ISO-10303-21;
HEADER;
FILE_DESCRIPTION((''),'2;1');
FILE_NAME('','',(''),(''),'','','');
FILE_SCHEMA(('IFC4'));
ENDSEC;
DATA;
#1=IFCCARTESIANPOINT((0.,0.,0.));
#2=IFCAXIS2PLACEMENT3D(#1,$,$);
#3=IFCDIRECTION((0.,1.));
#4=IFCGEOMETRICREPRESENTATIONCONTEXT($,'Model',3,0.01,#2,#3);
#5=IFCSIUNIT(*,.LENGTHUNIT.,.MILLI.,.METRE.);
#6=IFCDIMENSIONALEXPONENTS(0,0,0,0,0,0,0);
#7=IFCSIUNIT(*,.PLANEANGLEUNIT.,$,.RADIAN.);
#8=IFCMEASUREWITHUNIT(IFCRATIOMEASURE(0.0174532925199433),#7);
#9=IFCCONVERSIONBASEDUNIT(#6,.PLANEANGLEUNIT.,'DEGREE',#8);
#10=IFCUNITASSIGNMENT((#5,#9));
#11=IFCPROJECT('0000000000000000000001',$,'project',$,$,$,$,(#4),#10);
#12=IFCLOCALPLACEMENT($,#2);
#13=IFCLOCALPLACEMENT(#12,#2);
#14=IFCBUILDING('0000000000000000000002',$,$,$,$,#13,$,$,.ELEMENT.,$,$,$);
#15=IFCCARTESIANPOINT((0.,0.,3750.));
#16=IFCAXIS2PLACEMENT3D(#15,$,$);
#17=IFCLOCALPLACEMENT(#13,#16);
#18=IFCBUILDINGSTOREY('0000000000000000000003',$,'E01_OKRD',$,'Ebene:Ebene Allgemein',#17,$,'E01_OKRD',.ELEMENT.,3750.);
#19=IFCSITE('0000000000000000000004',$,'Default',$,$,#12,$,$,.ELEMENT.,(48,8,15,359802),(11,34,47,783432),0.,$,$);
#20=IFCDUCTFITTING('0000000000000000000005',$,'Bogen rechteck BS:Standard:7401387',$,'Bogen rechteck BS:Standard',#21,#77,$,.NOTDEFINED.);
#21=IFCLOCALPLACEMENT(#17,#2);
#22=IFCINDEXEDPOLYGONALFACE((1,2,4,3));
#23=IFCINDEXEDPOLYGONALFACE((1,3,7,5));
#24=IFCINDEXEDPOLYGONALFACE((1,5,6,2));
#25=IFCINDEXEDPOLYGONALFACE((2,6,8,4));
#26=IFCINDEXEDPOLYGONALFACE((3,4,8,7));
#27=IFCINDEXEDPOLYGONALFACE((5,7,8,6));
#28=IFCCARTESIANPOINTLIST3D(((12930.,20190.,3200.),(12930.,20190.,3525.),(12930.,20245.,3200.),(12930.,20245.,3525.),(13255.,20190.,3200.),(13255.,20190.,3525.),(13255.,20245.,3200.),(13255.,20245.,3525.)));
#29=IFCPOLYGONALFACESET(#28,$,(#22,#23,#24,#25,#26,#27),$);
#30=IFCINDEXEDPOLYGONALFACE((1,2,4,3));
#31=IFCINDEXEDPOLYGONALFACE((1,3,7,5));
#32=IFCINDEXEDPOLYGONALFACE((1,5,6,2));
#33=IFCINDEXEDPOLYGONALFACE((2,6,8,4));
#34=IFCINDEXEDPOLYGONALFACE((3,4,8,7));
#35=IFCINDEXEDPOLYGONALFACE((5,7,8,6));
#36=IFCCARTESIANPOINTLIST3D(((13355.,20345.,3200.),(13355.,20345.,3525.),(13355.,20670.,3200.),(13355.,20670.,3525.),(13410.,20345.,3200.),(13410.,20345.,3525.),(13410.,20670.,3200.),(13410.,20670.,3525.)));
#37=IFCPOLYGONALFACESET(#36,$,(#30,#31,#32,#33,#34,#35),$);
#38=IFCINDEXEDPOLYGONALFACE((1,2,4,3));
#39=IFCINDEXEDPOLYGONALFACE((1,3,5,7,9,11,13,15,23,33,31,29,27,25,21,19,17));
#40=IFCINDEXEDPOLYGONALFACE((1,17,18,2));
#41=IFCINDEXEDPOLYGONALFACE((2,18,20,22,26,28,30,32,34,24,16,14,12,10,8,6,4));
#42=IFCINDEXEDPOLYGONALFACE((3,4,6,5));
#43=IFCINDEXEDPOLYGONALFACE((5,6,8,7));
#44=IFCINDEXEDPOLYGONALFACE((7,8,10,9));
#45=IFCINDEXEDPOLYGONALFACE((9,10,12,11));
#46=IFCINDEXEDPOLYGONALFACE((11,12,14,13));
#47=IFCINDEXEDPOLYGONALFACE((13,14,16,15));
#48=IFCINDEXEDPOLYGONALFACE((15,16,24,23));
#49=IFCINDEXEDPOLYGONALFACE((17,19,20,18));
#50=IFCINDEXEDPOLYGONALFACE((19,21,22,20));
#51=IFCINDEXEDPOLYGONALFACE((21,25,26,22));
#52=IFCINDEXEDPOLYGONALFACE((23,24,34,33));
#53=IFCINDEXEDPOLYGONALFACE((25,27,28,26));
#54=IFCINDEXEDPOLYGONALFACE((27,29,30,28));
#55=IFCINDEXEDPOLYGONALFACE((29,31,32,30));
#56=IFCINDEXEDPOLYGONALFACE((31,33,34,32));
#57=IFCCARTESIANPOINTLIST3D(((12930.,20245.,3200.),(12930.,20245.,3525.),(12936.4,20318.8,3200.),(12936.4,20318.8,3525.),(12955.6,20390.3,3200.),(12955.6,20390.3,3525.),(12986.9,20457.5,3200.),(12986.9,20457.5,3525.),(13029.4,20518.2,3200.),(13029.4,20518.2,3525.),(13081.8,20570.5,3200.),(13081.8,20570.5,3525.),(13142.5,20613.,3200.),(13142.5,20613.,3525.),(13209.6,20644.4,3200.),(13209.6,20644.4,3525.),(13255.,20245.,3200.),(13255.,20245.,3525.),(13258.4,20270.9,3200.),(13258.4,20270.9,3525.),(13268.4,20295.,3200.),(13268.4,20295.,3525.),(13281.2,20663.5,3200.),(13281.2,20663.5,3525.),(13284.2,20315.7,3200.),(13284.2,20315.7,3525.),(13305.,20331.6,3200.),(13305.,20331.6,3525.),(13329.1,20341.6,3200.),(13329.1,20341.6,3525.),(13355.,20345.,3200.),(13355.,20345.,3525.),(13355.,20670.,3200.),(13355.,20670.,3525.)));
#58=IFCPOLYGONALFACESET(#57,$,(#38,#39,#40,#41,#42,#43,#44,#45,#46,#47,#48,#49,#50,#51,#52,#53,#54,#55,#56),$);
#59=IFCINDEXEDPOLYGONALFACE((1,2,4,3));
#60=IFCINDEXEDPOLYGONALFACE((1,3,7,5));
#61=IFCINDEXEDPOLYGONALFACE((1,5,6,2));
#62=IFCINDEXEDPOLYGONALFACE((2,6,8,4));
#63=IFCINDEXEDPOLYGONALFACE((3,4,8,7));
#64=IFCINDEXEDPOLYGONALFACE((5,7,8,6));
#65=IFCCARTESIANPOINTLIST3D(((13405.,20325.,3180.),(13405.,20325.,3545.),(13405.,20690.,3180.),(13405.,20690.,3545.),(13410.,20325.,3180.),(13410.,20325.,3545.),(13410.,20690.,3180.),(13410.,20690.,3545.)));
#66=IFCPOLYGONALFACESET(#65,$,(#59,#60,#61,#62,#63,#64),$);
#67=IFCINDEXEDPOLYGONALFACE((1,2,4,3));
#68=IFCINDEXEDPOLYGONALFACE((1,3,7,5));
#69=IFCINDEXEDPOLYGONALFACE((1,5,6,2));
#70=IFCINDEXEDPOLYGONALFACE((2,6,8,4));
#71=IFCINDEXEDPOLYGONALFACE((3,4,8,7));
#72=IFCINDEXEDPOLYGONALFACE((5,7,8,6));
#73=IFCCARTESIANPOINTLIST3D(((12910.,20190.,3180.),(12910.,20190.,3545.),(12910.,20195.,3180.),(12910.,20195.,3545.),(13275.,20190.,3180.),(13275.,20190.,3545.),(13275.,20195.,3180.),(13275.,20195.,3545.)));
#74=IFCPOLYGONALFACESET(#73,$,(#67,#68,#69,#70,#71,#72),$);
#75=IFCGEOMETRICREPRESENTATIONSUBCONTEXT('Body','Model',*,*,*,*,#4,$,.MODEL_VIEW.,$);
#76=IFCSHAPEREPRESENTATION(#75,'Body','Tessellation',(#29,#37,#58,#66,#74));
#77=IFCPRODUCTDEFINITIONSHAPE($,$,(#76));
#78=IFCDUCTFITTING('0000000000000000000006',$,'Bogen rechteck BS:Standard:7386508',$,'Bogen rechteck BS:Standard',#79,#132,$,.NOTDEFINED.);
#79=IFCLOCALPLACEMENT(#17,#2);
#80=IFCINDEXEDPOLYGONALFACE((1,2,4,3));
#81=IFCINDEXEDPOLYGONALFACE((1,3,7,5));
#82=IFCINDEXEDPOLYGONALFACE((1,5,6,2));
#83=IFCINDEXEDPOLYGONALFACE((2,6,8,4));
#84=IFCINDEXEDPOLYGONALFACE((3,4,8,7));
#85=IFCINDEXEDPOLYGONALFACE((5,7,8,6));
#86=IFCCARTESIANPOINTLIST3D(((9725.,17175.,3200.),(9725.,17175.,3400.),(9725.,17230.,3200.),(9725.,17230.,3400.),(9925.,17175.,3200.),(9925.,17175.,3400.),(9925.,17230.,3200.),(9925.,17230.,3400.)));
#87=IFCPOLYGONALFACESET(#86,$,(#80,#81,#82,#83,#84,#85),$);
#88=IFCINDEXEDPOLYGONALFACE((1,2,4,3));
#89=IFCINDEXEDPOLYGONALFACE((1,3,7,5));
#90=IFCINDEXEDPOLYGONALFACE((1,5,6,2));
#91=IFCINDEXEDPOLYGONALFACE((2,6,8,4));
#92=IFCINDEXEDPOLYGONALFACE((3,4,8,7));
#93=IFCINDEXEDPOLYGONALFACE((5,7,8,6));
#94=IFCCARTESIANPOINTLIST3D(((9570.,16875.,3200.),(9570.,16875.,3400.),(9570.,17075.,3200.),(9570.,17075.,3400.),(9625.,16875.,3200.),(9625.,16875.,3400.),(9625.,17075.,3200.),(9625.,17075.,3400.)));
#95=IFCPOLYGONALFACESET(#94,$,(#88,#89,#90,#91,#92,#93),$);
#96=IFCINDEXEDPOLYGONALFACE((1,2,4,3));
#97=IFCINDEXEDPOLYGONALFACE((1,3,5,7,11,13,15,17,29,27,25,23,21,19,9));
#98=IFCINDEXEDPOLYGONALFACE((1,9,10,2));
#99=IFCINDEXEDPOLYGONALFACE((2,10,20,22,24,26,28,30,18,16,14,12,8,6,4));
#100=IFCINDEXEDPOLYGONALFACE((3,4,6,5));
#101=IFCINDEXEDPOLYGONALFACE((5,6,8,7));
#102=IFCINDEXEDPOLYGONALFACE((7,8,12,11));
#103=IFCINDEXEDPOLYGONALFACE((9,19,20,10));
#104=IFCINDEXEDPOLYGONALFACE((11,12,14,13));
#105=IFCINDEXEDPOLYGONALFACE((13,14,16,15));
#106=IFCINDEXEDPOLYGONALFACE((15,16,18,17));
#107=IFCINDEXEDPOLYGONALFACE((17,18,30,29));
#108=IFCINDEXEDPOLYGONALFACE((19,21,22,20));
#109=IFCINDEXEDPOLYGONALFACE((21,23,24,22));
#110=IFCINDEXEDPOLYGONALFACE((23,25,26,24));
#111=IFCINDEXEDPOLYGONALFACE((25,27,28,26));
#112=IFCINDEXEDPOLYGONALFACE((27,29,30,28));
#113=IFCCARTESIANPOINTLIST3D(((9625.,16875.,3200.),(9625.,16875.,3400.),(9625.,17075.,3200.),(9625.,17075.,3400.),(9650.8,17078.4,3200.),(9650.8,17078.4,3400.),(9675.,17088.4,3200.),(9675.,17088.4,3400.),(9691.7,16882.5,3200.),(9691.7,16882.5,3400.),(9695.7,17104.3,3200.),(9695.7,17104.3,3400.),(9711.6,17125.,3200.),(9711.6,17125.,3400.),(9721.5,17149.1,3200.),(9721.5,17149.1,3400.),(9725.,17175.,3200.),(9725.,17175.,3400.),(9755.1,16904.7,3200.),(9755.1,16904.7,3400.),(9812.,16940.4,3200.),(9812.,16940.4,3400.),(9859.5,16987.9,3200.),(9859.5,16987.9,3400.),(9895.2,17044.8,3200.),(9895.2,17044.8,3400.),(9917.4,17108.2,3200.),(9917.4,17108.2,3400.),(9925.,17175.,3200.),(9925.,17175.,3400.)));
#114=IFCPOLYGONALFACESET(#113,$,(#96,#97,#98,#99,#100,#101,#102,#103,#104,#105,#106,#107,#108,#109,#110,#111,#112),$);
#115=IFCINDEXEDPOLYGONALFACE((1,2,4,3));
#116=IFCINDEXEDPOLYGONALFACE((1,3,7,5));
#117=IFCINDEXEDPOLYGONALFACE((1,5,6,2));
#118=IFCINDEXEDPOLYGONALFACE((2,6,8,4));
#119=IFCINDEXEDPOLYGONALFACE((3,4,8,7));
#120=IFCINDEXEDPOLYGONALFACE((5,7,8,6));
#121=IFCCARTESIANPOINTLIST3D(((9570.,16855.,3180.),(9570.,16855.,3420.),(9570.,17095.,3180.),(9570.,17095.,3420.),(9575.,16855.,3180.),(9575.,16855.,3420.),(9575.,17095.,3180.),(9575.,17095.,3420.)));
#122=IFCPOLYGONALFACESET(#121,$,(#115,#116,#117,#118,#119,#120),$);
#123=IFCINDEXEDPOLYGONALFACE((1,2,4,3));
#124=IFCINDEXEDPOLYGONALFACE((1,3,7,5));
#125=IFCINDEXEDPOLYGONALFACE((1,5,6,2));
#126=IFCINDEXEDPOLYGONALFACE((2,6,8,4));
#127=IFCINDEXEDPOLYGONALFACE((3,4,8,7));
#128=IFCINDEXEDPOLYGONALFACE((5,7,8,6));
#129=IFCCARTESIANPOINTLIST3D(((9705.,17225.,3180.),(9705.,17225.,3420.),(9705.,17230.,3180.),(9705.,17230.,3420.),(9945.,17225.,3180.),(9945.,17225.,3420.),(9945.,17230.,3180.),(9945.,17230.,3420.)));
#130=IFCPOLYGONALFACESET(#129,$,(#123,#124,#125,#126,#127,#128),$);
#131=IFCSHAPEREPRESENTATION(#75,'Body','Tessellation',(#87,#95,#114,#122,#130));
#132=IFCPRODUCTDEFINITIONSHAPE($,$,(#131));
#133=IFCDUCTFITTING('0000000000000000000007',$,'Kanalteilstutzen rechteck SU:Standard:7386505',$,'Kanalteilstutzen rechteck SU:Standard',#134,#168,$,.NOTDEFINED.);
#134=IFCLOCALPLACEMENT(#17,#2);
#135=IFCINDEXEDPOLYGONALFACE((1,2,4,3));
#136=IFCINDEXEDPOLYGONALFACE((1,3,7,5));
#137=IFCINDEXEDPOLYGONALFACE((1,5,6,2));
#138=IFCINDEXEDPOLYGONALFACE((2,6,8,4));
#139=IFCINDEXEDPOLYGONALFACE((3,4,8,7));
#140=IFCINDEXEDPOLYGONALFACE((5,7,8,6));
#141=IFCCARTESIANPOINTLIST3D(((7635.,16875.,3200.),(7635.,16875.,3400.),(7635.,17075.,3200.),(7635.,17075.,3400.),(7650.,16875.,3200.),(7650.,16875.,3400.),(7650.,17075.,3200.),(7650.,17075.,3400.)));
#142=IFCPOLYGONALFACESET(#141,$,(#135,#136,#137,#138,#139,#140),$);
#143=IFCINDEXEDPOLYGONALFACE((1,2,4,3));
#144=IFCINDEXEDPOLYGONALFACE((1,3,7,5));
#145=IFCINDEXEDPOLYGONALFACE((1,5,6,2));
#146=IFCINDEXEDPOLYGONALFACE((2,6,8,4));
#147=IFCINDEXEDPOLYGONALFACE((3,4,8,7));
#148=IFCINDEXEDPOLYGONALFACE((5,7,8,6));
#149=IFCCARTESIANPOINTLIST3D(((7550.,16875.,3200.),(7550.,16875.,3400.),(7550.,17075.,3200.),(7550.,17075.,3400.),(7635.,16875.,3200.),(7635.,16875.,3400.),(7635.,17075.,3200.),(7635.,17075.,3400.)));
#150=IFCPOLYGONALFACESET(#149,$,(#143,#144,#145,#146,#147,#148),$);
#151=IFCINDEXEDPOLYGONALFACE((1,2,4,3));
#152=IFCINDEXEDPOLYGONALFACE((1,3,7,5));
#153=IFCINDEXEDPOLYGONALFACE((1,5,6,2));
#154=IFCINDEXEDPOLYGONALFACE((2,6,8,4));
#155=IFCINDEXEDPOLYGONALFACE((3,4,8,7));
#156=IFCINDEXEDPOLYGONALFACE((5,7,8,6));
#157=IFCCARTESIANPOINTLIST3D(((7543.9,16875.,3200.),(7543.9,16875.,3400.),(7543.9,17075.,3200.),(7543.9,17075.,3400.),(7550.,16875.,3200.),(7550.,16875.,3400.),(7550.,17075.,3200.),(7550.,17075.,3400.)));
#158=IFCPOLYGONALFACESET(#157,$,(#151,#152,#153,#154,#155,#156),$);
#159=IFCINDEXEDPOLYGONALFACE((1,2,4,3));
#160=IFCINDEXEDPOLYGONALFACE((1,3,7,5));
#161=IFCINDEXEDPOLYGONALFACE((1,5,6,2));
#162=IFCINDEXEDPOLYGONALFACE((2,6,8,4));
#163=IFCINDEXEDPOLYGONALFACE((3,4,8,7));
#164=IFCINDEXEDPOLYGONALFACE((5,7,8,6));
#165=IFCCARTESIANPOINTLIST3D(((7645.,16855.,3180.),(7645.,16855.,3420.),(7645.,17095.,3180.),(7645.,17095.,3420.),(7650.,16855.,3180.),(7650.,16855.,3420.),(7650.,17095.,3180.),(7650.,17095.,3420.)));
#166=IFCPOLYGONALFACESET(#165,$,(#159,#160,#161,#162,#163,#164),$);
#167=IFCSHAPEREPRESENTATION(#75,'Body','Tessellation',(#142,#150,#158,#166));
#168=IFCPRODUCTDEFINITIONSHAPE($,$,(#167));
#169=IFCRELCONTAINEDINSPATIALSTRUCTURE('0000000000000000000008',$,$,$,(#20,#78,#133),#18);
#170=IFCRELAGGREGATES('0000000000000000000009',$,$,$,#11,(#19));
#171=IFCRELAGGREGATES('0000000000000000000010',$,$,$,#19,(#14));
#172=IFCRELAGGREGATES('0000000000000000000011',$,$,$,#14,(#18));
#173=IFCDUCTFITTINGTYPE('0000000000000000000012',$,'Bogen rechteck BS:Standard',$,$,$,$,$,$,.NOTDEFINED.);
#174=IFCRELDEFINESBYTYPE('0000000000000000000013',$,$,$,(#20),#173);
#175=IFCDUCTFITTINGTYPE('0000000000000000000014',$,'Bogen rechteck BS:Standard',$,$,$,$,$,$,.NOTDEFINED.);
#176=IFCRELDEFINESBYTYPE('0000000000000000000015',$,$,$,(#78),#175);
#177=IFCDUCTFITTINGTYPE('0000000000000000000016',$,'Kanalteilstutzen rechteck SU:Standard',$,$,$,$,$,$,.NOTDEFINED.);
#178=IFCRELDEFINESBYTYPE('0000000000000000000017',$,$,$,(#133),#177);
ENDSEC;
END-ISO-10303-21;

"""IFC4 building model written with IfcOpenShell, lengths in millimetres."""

from ifc_helpers import new_model, entity, si_unit, converted_unit, direction, frame, frame_2d, origin, origin_2d_with_axis, place, context, subcontext, project, spatial, polyline, circle_curve, parameter, trimmed, segment, composite_curve, rectangle, outline, extrude, source, transform, mapped, type_object, type_shapes, element, save


model = new_model("IFC4")

# Units and contexts
model_context = context("Model", 3, precision=0.01, world=origin(), true_north=direction((0.0, 1.0)))
body_context = subcontext(model_context, "Body", "Model", "MODEL_VIEW")
ifc_project = project(units=[si_unit("LENGTHUNIT", "METRE", prefix="MILLI"), converted_unit("PLANEANGLEUNIT", "DEGREE", entity("IfcRatioMeasure", 0.0174532925199433), si_unit("PLANEANGLEUNIT", "RADIAN"), dimensions=[0, 0, 0, 0, 0, 0, 0])], contexts=[model_context])

# Site, building, storey
site_placement = place(None, origin())
site = spatial("IfcSite", under=ifc_project, at=site_placement, Name="Default", CompositionType="ELEMENT", RefLatitude=(48, 8, 15, 359802), RefLongitude=(11, 34, 47, 783432), RefElevation=0.0)
building_placement = place(site_placement, origin())
building = spatial("IfcBuilding", under=site, at=building_placement, CompositionType="ELEMENT")
storey_placement = place(building_placement, frame((0.0, 0.0, 3750.0)))
storey = spatial("IfcBuildingStorey", under=building, at=storey_placement, Name="E01_OKRD", ObjectType="Ebene:Ebene Allgemein", LongName="E01_OKRD", CompositionType="ELEMENT", Elevation=3750.0)

# Duct fittings
duct_fitting_type_1 = type_object("IfcDuctFittingType", Name="Bogen rechteck BS:Standard", PredefinedType="NOTDEFINED")
shared_shape_1 = source(origin(), body_context, "Body", "SweptSolid", [
    extrude(rectangle(XDim=55.0, YDim=325.0, at=frame_2d((0.0, 0.0), x_axis=(1.0, 0.0))), frame((0.0, 290.0, -162.5), z_axis=(0.0, 0.0, 1.0), x_axis=(0.0, 1.0, 0.0)), (0.0, 0.0, 1.0), 325.0),
    extrude(rectangle(XDim=325.0, YDim=55.0, at=frame_2d((0.0, 0.0), x_axis=(1.0, 0.0))), frame((-290.0, 0.0, -162.5), z_axis=(0.0, 0.0, 1.0), x_axis=(0.0, -1.0, 0.0)), (0.0, 0.0, 1.0), 325.0),
    extrude(outline(composite_curve([segment(polyline([(-293.8, -131.2), (31.2, -131.2)]), True, "CONTINUOUS"), segment(trimmed(circle_curve(frame_2d((131.2, -131.2), x_axis=(0.0, 1.0)), 100.0), [parameter(0.0)], [parameter(90.0)], True, "PARAMETER"), False, "CONTINUOUS"), segment(polyline([(131.2, -31.2), (131.2, 293.8)]), True, "CONTINUOUS"), segment(trimmed(circle_curve(frame_2d((131.2, -131.2), x_axis=(0.0, 1.0)), 425.0), [parameter(0.0)], [parameter(90.0)], True, "PARAMETER"), True, "CONTINUOUS")], self_intersect=False)), frame((-131.2, 131.3, -162.5), z_axis=(0.0, 0.0, 1.0), x_axis=(-1.0, 0.0, 0.0)), (0.0, 0.0, 1.0), 325.0),
    extrude(rectangle(XDim=5.0, YDim=365.0, at=frame_2d((0.0, 0.0), x_axis=(1.0, 0.0))), frame((-315.0, 0.0, -182.5)), (0.0, 0.0, 1.0), 365.0),
    extrude(rectangle(XDim=5.0, YDim=365.0, at=frame_2d((0.0, 0.0), x_axis=(1.0, 0.0))), frame((0.0, 315.0, -182.5), z_axis=(0.0, 0.0, 1.0), x_axis=(0.0, 1.0, 0.0)), (0.0, 0.0, 1.0), 365.0),
])
type_shapes(duct_fitting_type_1, [shared_shape_1])
duct_fitting_1_placement = place(storey_placement, frame((13092.5, 20507.5, 3362.5), z_axis=(0.0, 0.0, 1.0), x_axis=(-1.0, 0.0, 0.0)))
element("IfcDuctFitting", 1, at=duct_fitting_1_placement, inside=storey, type_object=duct_fitting_type_1, Name="Bogen rechteck BS:Standard:7401387", ObjectType="Bogen rechteck BS:Standard", PredefinedType="NOTDEFINED", context=body_context, shape_type="MappedRepresentation", body=[
    mapped(shared_shape_1, transform((0.0, 0.0, 0.0), scale=1.0)),
])
duct_fitting_type_2 = type_object("IfcDuctFittingType", Name="Bogen rechteck BS:Standard", PredefinedType="NOTDEFINED")
shared_shape_2 = source(origin(), body_context, "Body", "SweptSolid", [
    extrude(rectangle(XDim=55.0, YDim=200.0, at=frame_2d((0.0, 0.0), x_axis=(1.0, 0.0))), frame((0.0, 227.5, -100.0), z_axis=(0.0, 0.0, 1.0), x_axis=(0.0, 1.0, 0.0)), (0.0, 0.0, 1.0), 200.0),
    extrude(rectangle(XDim=200.0, YDim=55.0, at=frame_2d((0.0, 0.0), x_axis=(1.0, 0.0))), frame((-227.5, 0.0, -100.0), z_axis=(0.0, 0.0, 1.0), x_axis=(0.0, -1.0, 0.0)), (0.0, 0.0, 1.0), 200.0),
    extrude(outline(composite_curve([segment(polyline([(-200.0, -100.0), (0.0, -100.0)]), True, "CONTINUOUS"), segment(trimmed(circle_curve(frame_2d((100.0, -100.0), x_axis=(0.0, 1.0)), 100.0), [parameter(0.0)], [parameter(90.0)], True, "PARAMETER"), False, "CONTINUOUS"), segment(polyline([(100.0, 0.0), (100.0, 200.0)]), True, "CONTINUOUS"), segment(trimmed(circle_curve(frame_2d((100.0, -100.0), x_axis=(0.0, 1.0)), 300.0), [parameter(0.0)], [parameter(90.0)], True, "PARAMETER"), True, "CONTINUOUS")], self_intersect=False)), frame((-100.0, 100.0, -100.0), z_axis=(0.0, 0.0, 1.0), x_axis=(-1.0, 0.0, 0.0)), (0.0, 0.0, 1.0), 200.0),
    extrude(rectangle(XDim=5.0, YDim=240.0, at=frame_2d((0.0, 0.0), x_axis=(1.0, 0.0))), frame((-252.5, 0.0, -120.0)), (0.0, 0.0, 1.0), 240.0),
    extrude(rectangle(XDim=5.0, YDim=240.0, at=frame_2d((0.0, 0.0), x_axis=(1.0, 0.0))), frame((0.0, 252.5, -120.0), z_axis=(0.0, 0.0, 1.0), x_axis=(0.0, 1.0, 0.0)), (0.0, 0.0, 1.0), 240.0),
])
type_shapes(duct_fitting_type_2, [shared_shape_2])
duct_fitting_2_placement = place(storey_placement, frame((9825.0, 16975.0, 3300.0)))
element("IfcDuctFitting", 2, at=duct_fitting_2_placement, inside=storey, type_object=duct_fitting_type_2, Name="Bogen rechteck BS:Standard:7386508", ObjectType="Bogen rechteck BS:Standard", PredefinedType="NOTDEFINED", context=body_context, shape_type="MappedRepresentation", body=[
    mapped(shared_shape_2, transform((0.0, 0.0, 0.0), scale=1.0)),
])
duct_fitting_type_3 = type_object("IfcDuctFittingType", Name="Kanalteilstutzen rechteck SU:Standard", PredefinedType="NOTDEFINED")
shared_shape_3 = source(origin(), body_context, "Body", "SweptSolid", [
    extrude(rectangle(XDim=200.0, YDim=15.0, at=origin_2d_with_axis()), frame((92.5, 0.0, -100.0), z_axis=(0.0, 0.0, 1.0), x_axis=(0.0, -1.0, 0.0)), (0.0, 0.0, 1.0), 200.0),
    extrude(rectangle(XDim=200.0, YDim=85.0, at=frame_2d((0.0, 0.0), x_axis=(1.0, 0.0))), frame((42.5, 0.0, -100.0), z_axis=(0.0, 0.0, 1.0), x_axis=(0.0, -1.0, 0.0)), (0.0, 0.0, 1.0), 200.0),
    extrude(rectangle(XDim=200.0, YDim=6.1, at=frame_2d((0.0, 0.0), x_axis=(1.0, 0.0))), frame((-3.0, 0.0, -100.0), z_axis=(0.0, 0.0, 1.0), x_axis=(0.0, -1.0, 0.0)), (0.0, 0.0, 1.0), 200.0),
    extrude(rectangle(XDim=240.0, YDim=5.0, at=origin_2d_with_axis()), frame((97.5, 0.0, -120.0), z_axis=(0.0, 0.0, 1.0), x_axis=(0.0, -1.0, 0.0)), (0.0, 0.0, 1.0), 240.0),
])
type_shapes(duct_fitting_type_3, [shared_shape_3])
duct_fitting_3_placement = place(storey_placement, frame((7550.0, 16975.0, 3300.0), z_axis=(0.0, 0.0, -1.0), x_axis=(1.0, 0.0, 0.0)))
element("IfcDuctFitting", 3, at=duct_fitting_3_placement, inside=storey, type_object=duct_fitting_type_3, Name="Kanalteilstutzen rechteck SU:Standard:7386505", ObjectType="Kanalteilstutzen rechteck SU:Standard", PredefinedType="NOTDEFINED", context=body_context, shape_type="MappedRepresentation", body=[
    mapped(shared_shape_3, transform((0.0, 0.0, 0.0), scale=1.0)),
])

save(model, "model.ifc")
